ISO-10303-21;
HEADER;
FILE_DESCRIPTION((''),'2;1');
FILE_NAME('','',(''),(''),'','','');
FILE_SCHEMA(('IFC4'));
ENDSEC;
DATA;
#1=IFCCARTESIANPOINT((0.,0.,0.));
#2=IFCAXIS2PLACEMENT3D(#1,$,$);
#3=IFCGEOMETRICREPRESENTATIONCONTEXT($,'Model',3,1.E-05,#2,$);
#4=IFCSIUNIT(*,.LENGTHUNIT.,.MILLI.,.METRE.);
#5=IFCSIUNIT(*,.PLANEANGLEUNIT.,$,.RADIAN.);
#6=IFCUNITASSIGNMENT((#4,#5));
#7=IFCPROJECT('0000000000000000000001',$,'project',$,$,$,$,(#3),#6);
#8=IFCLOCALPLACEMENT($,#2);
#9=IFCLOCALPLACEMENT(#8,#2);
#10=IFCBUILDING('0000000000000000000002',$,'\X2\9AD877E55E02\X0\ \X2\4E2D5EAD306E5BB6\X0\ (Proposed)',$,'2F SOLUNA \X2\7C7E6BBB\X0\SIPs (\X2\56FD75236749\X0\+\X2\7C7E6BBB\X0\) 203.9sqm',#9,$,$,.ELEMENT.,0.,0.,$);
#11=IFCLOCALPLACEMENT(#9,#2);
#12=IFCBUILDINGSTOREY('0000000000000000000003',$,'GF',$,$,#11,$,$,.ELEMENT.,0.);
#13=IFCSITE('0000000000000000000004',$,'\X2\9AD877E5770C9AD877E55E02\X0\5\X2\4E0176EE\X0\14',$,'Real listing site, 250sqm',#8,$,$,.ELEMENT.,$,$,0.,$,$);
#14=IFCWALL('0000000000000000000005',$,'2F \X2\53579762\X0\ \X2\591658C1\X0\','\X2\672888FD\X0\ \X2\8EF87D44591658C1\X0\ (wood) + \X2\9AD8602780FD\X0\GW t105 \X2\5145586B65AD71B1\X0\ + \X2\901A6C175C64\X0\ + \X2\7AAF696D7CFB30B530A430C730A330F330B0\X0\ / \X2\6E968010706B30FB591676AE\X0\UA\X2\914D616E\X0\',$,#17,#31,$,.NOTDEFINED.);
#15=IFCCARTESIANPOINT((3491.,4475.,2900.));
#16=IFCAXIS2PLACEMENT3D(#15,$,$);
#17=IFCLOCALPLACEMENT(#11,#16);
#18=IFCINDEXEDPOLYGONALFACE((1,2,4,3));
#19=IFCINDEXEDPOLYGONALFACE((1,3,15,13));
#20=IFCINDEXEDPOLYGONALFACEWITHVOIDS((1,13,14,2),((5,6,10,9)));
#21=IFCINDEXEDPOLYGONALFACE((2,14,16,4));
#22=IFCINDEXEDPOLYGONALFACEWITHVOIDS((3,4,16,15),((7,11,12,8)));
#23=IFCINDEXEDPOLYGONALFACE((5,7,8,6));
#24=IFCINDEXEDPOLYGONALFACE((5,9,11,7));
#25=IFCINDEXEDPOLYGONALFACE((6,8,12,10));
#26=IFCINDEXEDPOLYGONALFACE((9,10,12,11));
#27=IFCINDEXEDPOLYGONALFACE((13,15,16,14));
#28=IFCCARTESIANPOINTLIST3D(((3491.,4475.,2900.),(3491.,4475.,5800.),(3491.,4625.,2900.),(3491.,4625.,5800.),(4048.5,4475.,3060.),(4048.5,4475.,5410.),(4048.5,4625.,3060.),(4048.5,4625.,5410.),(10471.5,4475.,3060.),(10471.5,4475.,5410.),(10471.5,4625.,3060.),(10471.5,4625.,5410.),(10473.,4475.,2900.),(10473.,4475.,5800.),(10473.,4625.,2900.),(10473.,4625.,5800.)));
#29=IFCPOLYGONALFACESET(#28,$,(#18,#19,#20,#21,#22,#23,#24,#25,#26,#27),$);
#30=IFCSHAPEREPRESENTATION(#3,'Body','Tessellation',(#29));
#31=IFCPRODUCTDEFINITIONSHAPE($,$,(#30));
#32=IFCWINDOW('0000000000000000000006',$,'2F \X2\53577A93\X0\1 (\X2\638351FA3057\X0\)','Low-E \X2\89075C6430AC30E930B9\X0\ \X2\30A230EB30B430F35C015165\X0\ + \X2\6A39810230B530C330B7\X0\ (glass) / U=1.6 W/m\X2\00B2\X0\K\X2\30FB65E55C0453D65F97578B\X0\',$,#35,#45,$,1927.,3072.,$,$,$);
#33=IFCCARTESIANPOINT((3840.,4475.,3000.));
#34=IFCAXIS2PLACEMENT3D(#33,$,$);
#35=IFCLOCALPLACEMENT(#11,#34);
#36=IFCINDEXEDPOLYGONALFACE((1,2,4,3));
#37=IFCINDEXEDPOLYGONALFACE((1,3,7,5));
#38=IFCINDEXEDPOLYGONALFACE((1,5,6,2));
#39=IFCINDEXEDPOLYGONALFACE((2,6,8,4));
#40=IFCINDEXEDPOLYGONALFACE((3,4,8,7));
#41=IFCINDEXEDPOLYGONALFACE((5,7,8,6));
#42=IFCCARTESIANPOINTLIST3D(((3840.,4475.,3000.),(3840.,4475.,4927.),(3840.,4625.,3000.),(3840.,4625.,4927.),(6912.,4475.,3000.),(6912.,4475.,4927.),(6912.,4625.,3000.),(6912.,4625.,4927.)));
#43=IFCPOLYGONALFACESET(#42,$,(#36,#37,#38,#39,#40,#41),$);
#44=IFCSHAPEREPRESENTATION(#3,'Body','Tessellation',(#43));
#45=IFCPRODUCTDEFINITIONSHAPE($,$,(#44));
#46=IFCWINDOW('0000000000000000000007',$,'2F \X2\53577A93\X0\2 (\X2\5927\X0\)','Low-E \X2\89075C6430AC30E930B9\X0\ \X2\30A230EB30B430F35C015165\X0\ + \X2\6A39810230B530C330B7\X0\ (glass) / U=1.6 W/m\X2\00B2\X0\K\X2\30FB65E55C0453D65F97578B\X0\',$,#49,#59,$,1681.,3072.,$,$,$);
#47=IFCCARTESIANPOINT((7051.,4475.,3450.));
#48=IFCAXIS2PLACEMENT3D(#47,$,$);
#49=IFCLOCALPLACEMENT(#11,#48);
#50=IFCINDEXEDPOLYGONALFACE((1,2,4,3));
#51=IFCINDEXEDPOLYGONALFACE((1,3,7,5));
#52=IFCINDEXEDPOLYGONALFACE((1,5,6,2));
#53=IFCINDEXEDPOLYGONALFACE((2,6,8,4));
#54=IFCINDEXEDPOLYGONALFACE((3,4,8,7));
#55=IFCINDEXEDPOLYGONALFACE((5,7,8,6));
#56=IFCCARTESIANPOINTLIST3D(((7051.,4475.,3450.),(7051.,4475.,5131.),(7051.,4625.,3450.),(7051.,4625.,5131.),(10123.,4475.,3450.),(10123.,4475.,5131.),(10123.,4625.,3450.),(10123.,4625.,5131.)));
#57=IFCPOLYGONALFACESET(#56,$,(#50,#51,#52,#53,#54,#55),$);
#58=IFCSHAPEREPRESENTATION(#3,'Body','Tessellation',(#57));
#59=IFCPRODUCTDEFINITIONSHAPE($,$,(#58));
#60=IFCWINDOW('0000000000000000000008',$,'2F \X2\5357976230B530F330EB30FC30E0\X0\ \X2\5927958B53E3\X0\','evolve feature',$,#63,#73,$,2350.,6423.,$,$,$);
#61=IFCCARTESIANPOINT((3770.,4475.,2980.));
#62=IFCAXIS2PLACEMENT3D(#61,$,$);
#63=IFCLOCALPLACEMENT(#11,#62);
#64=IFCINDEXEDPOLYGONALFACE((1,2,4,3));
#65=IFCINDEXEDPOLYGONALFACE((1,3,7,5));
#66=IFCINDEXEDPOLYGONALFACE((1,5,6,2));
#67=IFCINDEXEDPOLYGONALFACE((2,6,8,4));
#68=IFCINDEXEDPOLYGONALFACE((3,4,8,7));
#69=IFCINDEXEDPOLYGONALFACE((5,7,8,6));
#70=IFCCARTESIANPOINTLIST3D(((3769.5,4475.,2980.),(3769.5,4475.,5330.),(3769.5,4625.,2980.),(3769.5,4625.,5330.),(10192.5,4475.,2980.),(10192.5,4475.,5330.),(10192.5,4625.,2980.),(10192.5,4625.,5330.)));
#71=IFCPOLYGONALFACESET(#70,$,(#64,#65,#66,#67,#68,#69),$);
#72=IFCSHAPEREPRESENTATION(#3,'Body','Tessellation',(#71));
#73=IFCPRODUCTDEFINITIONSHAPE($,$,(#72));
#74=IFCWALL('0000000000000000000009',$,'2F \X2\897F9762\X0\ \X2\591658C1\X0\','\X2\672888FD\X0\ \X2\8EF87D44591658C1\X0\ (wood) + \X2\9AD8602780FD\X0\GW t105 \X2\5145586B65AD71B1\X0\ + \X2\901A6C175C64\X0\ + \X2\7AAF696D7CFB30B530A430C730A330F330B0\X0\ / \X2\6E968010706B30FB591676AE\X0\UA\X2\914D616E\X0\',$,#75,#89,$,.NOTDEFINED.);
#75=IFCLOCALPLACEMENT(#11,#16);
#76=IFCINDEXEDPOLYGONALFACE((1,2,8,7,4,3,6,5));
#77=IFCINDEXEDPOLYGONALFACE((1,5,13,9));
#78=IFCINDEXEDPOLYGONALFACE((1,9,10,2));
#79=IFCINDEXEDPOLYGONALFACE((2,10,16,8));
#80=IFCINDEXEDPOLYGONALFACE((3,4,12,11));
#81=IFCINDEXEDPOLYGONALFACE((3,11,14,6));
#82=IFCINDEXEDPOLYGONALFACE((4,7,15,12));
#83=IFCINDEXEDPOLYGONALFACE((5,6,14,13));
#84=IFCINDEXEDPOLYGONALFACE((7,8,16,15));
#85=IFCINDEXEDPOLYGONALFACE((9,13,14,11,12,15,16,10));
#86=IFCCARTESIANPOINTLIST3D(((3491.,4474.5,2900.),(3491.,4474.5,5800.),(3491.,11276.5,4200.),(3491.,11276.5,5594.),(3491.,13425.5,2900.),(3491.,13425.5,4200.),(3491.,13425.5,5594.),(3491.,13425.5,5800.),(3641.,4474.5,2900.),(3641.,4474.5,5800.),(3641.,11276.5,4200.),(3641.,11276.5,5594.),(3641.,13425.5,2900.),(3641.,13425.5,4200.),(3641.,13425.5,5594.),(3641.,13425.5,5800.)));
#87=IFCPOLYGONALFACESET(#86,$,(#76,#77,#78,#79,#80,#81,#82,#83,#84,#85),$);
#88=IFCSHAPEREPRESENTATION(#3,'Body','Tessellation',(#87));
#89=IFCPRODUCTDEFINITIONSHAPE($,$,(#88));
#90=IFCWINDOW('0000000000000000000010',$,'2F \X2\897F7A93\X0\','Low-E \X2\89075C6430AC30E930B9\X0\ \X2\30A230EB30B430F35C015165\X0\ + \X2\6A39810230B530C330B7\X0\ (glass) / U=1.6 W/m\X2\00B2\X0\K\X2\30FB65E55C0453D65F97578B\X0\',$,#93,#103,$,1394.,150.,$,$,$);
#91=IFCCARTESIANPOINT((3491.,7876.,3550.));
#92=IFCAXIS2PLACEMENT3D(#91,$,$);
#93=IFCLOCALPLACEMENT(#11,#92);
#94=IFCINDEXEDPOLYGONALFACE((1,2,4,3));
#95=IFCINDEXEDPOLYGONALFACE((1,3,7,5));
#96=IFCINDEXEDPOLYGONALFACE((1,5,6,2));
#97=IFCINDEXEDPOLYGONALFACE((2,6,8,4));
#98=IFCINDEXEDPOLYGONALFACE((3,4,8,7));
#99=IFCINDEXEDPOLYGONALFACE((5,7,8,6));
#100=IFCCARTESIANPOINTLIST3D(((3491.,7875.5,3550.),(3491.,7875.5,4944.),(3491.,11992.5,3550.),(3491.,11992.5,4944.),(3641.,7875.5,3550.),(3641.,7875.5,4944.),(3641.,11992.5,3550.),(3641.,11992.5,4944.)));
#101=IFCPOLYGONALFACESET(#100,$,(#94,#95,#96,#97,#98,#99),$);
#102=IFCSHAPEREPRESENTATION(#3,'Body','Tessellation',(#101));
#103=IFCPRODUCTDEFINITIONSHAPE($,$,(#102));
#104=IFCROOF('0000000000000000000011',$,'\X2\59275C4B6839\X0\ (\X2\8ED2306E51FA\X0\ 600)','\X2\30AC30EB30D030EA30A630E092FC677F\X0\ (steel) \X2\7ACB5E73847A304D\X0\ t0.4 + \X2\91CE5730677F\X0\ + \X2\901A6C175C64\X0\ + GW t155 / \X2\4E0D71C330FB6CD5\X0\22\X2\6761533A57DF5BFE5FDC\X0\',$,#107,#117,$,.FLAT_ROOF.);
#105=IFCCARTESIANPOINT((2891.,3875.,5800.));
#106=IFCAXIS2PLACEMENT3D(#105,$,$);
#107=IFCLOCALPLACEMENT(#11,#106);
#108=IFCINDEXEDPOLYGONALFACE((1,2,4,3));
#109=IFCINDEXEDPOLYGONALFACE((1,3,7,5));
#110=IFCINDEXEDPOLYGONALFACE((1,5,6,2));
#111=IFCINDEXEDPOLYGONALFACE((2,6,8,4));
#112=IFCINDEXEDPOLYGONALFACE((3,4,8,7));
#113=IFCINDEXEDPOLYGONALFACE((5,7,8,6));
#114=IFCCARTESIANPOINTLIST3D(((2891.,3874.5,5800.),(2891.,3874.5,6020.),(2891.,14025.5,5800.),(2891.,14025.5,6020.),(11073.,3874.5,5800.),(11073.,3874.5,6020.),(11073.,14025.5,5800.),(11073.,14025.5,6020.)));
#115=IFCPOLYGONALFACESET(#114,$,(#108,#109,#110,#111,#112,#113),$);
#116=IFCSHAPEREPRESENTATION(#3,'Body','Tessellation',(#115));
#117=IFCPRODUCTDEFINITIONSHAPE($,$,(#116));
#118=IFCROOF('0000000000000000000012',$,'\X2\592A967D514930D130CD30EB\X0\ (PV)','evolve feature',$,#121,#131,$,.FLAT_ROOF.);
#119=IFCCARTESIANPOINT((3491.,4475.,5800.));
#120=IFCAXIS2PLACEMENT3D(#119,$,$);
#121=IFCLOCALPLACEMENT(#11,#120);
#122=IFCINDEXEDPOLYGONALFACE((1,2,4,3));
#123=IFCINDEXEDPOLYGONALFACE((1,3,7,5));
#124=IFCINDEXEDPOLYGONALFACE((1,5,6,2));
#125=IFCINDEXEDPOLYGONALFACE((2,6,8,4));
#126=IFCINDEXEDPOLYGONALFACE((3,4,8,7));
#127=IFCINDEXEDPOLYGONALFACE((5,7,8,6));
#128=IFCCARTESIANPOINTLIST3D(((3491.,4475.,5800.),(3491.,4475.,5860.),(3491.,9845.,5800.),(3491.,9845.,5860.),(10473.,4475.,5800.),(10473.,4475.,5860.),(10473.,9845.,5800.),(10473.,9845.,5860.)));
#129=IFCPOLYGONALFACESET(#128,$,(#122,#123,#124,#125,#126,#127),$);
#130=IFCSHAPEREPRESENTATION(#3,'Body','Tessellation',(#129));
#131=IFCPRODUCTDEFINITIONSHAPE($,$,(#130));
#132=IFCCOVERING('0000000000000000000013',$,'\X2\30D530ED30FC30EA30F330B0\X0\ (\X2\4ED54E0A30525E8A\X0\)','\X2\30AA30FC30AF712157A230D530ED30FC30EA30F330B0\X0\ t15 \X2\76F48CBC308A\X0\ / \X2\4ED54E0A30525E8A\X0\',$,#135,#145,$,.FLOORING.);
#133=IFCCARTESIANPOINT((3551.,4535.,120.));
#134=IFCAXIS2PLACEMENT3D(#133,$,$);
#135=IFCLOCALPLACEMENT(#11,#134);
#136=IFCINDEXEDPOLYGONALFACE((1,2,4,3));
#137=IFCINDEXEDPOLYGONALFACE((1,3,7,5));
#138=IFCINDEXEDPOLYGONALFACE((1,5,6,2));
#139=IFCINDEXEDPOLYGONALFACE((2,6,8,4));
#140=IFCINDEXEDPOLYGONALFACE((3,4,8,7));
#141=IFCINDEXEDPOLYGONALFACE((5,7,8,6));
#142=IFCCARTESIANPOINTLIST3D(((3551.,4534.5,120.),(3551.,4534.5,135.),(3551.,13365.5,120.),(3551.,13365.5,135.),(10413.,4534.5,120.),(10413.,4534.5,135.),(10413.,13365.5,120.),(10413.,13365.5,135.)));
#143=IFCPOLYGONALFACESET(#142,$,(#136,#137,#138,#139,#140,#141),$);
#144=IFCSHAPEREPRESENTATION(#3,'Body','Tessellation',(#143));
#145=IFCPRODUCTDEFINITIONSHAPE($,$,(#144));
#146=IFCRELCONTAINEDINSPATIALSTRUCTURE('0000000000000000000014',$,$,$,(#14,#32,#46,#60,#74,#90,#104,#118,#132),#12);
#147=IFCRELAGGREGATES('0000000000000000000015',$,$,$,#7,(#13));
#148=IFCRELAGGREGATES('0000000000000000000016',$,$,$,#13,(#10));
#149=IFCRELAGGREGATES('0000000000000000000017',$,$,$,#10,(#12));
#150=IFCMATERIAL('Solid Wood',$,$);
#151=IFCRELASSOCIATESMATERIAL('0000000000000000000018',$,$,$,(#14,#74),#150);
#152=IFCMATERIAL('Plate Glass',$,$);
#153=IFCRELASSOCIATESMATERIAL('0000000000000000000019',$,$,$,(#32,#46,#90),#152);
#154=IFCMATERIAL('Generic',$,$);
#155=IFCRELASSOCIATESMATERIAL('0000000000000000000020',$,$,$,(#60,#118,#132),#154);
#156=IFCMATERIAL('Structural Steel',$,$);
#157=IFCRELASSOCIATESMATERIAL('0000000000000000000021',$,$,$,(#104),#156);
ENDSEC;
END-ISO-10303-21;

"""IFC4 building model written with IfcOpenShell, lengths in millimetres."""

from ifc_helpers import new_model, si_unit, frame, frame_2d, origin, place, context, project, spatial, rectangle, extrude, material, element, fill, save


model = new_model("IFC4")

# Units and contexts
model_context = context("Model", 3, precision=1e-05, world=origin())
ifc_project = project(units=[si_unit("LENGTHUNIT", "METRE", prefix="MILLI"), si_unit("PLANEANGLEUNIT", "RADIAN")], contexts=[model_context])

# Site, building, storey
site_placement = place(None, origin())
site = spatial("IfcSite", under=ifc_project, at=site_placement, Name="高知県高知市5丁目14", ObjectType="Real listing site, 250sqm", CompositionType="ELEMENT", RefElevation=0.0)
building_placement = place(site_placement, origin())
building = spatial("IfcBuilding", under=site, at=building_placement, Name="高知市 中庭の家 (Proposed)", ObjectType="2F SOLUNA 籾殻SIPs (国産杉+籾殻) 203.9sqm", CompositionType="ELEMENT", ElevationOfRefHeight=0.0, ElevationOfTerrain=0.0)
storey_placement = place(building_placement, origin())
storey = spatial("IfcBuildingStorey", under=building, at=storey_placement, Name="GF", CompositionType="ELEMENT", Elevation=0.0)

# Shared definitions
ifc_material_1 = material(Name="Solid Wood")

# Shared definitions
ifc_material_2 = material(Name="Plate Glass")
ifc_material_3 = material(Name="Generic")

# Wall, openings, windows
wall_1_placement = place(storey_placement, frame((3491.0, 4475.0, 2900.0)))
wall_1 = element("IfcWall", 1, at=wall_1_placement, inside=storey, material=ifc_material_1, Name="2F 南面 外壁", Description="木製 軸組外壁 (wood) + 高性能GW t105 充填断熱 + 通気層 + 窯業系サイディング / 準耐火・外皮UA配慮", PredefinedType="NOTDEFINED", context=model_context, shape_type="SweptSolid", body=[
    extrude(rectangle(XDim=6982.0, YDim=150.0, at=frame_2d((3491.0, 75.0))), frame((3491.0, 4475.0, 2900.0)), (0.0, 0.0, 1.0), 2900.0),
])
opening_1_placement = place(storey_placement, frame((3840.0, 4475.0, 3000.0)))
opening_1 = element("IfcOpeningElement", 2, at=opening_1_placement, cuts=wall_1, PredefinedType="NOTDEFINED", context=model_context, shape_type="SweptSolid", body=[
    extrude(rectangle(XDim=3072.0, YDim=150.0, at=frame_2d((1536.0, 75.0))), frame((3840.0, 4475.0, 3000.0)), (0.0, 0.0, 1.0), 1927.0),
])
opening_2_placement = place(storey_placement, frame((7051.0, 4475.0, 3450.0)))
opening_2 = element("IfcOpeningElement", 3, at=opening_2_placement, cuts=wall_1, PredefinedType="NOTDEFINED", context=model_context, shape_type="SweptSolid", body=[
    extrude(rectangle(XDim=3072.0, YDim=150.0, at=frame_2d((1536.0, 75.0))), frame((7051.0, 4475.0, 3450.0)), (0.0, 0.0, 1.0), 1681.0),
])
opening_3_placement = place(storey_placement, frame((3770.0, 4475.0, 2980.0)))
opening_3 = element("IfcOpeningElement", 4, at=opening_3_placement, cuts=wall_1, PredefinedType="NOTDEFINED", context=model_context, shape_type="SweptSolid", body=[
    extrude(rectangle(XDim=6423.0, YDim=150.0, at=frame_2d((3211.0, 75.0))), frame((3770.0, 4475.0, 2980.0)), (0.0, 0.0, 1.0), 2350.0),
])
window_1_placement = place(storey_placement, frame((3840.0, 4475.0, 3000.0)))
window_1 = element("IfcWindow", 5, at=window_1_placement, inside=storey, material=ifc_material_2, Name="2F 南窓1 (掃出し)", Description="Low-E 複層ガラス アルゴン封入 + 樹脂サッシ (glass) / U=1.6 W/m²K・日射取得型", OverallHeight=1927.0, OverallWidth=3072.0, context=model_context, shape_type="SweptSolid", body=[
    extrude(rectangle(XDim=3072.0, YDim=150.0, at=frame_2d((1536.0, 75.0))), frame((3840.0, 4475.0, 3000.0)), (0.0, 0.0, 1.0), 1927.0),
])
fill(opening_1, window_1)
window_2_placement = place(storey_placement, frame((7051.0, 4475.0, 3450.0)))
window_2 = element("IfcWindow", 6, at=window_2_placement, inside=storey, material=ifc_material_2, Name="2F 南窓2 (大)", Description="Low-E 複層ガラス アルゴン封入 + 樹脂サッシ (glass) / U=1.6 W/m²K・日射取得型", OverallHeight=1681.0, OverallWidth=3072.0, context=model_context, shape_type="SweptSolid", body=[
    extrude(rectangle(XDim=3072.0, YDim=150.0, at=frame_2d((1536.0, 75.0))), frame((7051.0, 4475.0, 3450.0)), (0.0, 0.0, 1.0), 1681.0),
])
fill(opening_2, window_2)
window_3_placement = place(storey_placement, frame((3770.0, 4475.0, 2980.0)))
window_3 = element("IfcWindow", 7, at=window_3_placement, inside=storey, material=ifc_material_3, Name="2F 南面サンルーム 大開口", Description="evolve feature", OverallHeight=2350.0, OverallWidth=6423.0, context=model_context, shape_type="SweptSolid", body=[
    extrude(rectangle(XDim=6423.0, YDim=150.0, at=frame_2d((3211.0, 75.0))), frame((3770.0, 4475.0, 2980.0)), (0.0, 0.0, 1.0), 2350.0),
])
fill(opening_3, window_3)

# Wall, opening, window
wall_2_placement = place(storey_placement, frame((3491.0, 4475.0, 2900.0)))
wall_2 = element("IfcWall", 8, at=wall_2_placement, inside=storey, material=ifc_material_1, Name="2F 西面 外壁", Description="木製 軸組外壁 (wood) + 高性能GW t105 充填断熱 + 通気層 + 窯業系サイディング / 準耐火・外皮UA配慮", PredefinedType="NOTDEFINED", context=model_context, shape_type="SweptSolid", body=[
    extrude(rectangle(XDim=150.0, YDim=8951.0, at=frame_2d((75.0, 4475.0))), frame((3491.0, 4475.0, 2900.0)), (0.0, 0.0, 1.0), 2900.0),
])
opening_4_placement = place(storey_placement, frame((3491.0, 7876.0, 3550.0)))
opening_4 = element("IfcOpeningElement", 9, at=opening_4_placement, cuts=wall_2, PredefinedType="NOTDEFINED", context=model_context, shape_type="SweptSolid", body=[
    extrude(rectangle(XDim=150.0, YDim=4117.0, at=frame_2d((75.0, 2058.0))), frame((3491.0, 7876.0, 3550.0)), (0.0, 0.0, 1.0), 1394.0),
])
window_4_placement = place(storey_placement, frame((3491.0, 7876.0, 3550.0)))
window_4 = element("IfcWindow", 10, at=window_4_placement, inside=storey, material=ifc_material_2, Name="2F 西窓", Description="Low-E 複層ガラス アルゴン封入 + 樹脂サッシ (glass) / U=1.6 W/m²K・日射取得型", OverallHeight=1394.0, OverallWidth=150.0, context=model_context, shape_type="SweptSolid", body=[
    extrude(rectangle(XDim=150.0, YDim=4117.0, at=frame_2d((75.0, 2058.0))), frame((3491.0, 7876.0, 3550.0)), (0.0, 0.0, 1.0), 1394.0),
])
fill(opening_4, window_4)

# Roofs
ifc_material_4 = material(Name="Structural Steel")
roof_1_placement = place(storey_placement, frame((2891.0, 3875.0, 5800.0)))
element("IfcRoof", 11, at=roof_1_placement, inside=storey, material=ifc_material_4, Name="大屋根 (軒の出 600)", Description="ガルバリウム鋼板 (steel) 立平葺き t0.4 + 野地板 + 通気層 + GW t155 / 不燃・法22条区域対応", PredefinedType="FLAT_ROOF", context=model_context, shape_type="SweptSolid", body=[
    extrude(rectangle(XDim=8182.0, YDim=10151.0, at=frame_2d((4091.0, 5075.0))), frame((2891.0, 3875.0, 5800.0)), (0.0, 0.0, 1.0), 220.0),
])
roof_2_placement = place(storey_placement, frame((3491.0, 4475.0, 5800.0)))
element("IfcRoof", 12, at=roof_2_placement, inside=storey, material=ifc_material_3, Name="太陽光パネル (PV)", Description="evolve feature", PredefinedType="FLAT_ROOF", context=model_context, shape_type="SweptSolid", body=[
    extrude(rectangle(XDim=6982.0, YDim=5370.0, at=frame_2d((3491.0, 2685.0))), frame((3491.0, 4475.0, 5800.0)), (0.0, 0.0, 1.0), 60.0),
])

# Covering
covering_placement = place(storey_placement, frame((3551.0, 4535.0, 120.0)))
element("IfcCovering", 13, at=covering_placement, inside=storey, material=ifc_material_3, Name="フローリング (仕上げ床)", Description="オーク無垢フローリング t15 直貼り / 仕上げ床", PredefinedType="FLOORING", context=model_context, shape_type="SweptSolid", body=[
    extrude(rectangle(XDim=6862.0, YDim=8831.0, at=frame_2d((3431.0, 4415.0))), frame((3551.0, 4535.0, 120.0)), (0.0, 0.0, 1.0), 15.0),
])

save(model, "model.ifc")
